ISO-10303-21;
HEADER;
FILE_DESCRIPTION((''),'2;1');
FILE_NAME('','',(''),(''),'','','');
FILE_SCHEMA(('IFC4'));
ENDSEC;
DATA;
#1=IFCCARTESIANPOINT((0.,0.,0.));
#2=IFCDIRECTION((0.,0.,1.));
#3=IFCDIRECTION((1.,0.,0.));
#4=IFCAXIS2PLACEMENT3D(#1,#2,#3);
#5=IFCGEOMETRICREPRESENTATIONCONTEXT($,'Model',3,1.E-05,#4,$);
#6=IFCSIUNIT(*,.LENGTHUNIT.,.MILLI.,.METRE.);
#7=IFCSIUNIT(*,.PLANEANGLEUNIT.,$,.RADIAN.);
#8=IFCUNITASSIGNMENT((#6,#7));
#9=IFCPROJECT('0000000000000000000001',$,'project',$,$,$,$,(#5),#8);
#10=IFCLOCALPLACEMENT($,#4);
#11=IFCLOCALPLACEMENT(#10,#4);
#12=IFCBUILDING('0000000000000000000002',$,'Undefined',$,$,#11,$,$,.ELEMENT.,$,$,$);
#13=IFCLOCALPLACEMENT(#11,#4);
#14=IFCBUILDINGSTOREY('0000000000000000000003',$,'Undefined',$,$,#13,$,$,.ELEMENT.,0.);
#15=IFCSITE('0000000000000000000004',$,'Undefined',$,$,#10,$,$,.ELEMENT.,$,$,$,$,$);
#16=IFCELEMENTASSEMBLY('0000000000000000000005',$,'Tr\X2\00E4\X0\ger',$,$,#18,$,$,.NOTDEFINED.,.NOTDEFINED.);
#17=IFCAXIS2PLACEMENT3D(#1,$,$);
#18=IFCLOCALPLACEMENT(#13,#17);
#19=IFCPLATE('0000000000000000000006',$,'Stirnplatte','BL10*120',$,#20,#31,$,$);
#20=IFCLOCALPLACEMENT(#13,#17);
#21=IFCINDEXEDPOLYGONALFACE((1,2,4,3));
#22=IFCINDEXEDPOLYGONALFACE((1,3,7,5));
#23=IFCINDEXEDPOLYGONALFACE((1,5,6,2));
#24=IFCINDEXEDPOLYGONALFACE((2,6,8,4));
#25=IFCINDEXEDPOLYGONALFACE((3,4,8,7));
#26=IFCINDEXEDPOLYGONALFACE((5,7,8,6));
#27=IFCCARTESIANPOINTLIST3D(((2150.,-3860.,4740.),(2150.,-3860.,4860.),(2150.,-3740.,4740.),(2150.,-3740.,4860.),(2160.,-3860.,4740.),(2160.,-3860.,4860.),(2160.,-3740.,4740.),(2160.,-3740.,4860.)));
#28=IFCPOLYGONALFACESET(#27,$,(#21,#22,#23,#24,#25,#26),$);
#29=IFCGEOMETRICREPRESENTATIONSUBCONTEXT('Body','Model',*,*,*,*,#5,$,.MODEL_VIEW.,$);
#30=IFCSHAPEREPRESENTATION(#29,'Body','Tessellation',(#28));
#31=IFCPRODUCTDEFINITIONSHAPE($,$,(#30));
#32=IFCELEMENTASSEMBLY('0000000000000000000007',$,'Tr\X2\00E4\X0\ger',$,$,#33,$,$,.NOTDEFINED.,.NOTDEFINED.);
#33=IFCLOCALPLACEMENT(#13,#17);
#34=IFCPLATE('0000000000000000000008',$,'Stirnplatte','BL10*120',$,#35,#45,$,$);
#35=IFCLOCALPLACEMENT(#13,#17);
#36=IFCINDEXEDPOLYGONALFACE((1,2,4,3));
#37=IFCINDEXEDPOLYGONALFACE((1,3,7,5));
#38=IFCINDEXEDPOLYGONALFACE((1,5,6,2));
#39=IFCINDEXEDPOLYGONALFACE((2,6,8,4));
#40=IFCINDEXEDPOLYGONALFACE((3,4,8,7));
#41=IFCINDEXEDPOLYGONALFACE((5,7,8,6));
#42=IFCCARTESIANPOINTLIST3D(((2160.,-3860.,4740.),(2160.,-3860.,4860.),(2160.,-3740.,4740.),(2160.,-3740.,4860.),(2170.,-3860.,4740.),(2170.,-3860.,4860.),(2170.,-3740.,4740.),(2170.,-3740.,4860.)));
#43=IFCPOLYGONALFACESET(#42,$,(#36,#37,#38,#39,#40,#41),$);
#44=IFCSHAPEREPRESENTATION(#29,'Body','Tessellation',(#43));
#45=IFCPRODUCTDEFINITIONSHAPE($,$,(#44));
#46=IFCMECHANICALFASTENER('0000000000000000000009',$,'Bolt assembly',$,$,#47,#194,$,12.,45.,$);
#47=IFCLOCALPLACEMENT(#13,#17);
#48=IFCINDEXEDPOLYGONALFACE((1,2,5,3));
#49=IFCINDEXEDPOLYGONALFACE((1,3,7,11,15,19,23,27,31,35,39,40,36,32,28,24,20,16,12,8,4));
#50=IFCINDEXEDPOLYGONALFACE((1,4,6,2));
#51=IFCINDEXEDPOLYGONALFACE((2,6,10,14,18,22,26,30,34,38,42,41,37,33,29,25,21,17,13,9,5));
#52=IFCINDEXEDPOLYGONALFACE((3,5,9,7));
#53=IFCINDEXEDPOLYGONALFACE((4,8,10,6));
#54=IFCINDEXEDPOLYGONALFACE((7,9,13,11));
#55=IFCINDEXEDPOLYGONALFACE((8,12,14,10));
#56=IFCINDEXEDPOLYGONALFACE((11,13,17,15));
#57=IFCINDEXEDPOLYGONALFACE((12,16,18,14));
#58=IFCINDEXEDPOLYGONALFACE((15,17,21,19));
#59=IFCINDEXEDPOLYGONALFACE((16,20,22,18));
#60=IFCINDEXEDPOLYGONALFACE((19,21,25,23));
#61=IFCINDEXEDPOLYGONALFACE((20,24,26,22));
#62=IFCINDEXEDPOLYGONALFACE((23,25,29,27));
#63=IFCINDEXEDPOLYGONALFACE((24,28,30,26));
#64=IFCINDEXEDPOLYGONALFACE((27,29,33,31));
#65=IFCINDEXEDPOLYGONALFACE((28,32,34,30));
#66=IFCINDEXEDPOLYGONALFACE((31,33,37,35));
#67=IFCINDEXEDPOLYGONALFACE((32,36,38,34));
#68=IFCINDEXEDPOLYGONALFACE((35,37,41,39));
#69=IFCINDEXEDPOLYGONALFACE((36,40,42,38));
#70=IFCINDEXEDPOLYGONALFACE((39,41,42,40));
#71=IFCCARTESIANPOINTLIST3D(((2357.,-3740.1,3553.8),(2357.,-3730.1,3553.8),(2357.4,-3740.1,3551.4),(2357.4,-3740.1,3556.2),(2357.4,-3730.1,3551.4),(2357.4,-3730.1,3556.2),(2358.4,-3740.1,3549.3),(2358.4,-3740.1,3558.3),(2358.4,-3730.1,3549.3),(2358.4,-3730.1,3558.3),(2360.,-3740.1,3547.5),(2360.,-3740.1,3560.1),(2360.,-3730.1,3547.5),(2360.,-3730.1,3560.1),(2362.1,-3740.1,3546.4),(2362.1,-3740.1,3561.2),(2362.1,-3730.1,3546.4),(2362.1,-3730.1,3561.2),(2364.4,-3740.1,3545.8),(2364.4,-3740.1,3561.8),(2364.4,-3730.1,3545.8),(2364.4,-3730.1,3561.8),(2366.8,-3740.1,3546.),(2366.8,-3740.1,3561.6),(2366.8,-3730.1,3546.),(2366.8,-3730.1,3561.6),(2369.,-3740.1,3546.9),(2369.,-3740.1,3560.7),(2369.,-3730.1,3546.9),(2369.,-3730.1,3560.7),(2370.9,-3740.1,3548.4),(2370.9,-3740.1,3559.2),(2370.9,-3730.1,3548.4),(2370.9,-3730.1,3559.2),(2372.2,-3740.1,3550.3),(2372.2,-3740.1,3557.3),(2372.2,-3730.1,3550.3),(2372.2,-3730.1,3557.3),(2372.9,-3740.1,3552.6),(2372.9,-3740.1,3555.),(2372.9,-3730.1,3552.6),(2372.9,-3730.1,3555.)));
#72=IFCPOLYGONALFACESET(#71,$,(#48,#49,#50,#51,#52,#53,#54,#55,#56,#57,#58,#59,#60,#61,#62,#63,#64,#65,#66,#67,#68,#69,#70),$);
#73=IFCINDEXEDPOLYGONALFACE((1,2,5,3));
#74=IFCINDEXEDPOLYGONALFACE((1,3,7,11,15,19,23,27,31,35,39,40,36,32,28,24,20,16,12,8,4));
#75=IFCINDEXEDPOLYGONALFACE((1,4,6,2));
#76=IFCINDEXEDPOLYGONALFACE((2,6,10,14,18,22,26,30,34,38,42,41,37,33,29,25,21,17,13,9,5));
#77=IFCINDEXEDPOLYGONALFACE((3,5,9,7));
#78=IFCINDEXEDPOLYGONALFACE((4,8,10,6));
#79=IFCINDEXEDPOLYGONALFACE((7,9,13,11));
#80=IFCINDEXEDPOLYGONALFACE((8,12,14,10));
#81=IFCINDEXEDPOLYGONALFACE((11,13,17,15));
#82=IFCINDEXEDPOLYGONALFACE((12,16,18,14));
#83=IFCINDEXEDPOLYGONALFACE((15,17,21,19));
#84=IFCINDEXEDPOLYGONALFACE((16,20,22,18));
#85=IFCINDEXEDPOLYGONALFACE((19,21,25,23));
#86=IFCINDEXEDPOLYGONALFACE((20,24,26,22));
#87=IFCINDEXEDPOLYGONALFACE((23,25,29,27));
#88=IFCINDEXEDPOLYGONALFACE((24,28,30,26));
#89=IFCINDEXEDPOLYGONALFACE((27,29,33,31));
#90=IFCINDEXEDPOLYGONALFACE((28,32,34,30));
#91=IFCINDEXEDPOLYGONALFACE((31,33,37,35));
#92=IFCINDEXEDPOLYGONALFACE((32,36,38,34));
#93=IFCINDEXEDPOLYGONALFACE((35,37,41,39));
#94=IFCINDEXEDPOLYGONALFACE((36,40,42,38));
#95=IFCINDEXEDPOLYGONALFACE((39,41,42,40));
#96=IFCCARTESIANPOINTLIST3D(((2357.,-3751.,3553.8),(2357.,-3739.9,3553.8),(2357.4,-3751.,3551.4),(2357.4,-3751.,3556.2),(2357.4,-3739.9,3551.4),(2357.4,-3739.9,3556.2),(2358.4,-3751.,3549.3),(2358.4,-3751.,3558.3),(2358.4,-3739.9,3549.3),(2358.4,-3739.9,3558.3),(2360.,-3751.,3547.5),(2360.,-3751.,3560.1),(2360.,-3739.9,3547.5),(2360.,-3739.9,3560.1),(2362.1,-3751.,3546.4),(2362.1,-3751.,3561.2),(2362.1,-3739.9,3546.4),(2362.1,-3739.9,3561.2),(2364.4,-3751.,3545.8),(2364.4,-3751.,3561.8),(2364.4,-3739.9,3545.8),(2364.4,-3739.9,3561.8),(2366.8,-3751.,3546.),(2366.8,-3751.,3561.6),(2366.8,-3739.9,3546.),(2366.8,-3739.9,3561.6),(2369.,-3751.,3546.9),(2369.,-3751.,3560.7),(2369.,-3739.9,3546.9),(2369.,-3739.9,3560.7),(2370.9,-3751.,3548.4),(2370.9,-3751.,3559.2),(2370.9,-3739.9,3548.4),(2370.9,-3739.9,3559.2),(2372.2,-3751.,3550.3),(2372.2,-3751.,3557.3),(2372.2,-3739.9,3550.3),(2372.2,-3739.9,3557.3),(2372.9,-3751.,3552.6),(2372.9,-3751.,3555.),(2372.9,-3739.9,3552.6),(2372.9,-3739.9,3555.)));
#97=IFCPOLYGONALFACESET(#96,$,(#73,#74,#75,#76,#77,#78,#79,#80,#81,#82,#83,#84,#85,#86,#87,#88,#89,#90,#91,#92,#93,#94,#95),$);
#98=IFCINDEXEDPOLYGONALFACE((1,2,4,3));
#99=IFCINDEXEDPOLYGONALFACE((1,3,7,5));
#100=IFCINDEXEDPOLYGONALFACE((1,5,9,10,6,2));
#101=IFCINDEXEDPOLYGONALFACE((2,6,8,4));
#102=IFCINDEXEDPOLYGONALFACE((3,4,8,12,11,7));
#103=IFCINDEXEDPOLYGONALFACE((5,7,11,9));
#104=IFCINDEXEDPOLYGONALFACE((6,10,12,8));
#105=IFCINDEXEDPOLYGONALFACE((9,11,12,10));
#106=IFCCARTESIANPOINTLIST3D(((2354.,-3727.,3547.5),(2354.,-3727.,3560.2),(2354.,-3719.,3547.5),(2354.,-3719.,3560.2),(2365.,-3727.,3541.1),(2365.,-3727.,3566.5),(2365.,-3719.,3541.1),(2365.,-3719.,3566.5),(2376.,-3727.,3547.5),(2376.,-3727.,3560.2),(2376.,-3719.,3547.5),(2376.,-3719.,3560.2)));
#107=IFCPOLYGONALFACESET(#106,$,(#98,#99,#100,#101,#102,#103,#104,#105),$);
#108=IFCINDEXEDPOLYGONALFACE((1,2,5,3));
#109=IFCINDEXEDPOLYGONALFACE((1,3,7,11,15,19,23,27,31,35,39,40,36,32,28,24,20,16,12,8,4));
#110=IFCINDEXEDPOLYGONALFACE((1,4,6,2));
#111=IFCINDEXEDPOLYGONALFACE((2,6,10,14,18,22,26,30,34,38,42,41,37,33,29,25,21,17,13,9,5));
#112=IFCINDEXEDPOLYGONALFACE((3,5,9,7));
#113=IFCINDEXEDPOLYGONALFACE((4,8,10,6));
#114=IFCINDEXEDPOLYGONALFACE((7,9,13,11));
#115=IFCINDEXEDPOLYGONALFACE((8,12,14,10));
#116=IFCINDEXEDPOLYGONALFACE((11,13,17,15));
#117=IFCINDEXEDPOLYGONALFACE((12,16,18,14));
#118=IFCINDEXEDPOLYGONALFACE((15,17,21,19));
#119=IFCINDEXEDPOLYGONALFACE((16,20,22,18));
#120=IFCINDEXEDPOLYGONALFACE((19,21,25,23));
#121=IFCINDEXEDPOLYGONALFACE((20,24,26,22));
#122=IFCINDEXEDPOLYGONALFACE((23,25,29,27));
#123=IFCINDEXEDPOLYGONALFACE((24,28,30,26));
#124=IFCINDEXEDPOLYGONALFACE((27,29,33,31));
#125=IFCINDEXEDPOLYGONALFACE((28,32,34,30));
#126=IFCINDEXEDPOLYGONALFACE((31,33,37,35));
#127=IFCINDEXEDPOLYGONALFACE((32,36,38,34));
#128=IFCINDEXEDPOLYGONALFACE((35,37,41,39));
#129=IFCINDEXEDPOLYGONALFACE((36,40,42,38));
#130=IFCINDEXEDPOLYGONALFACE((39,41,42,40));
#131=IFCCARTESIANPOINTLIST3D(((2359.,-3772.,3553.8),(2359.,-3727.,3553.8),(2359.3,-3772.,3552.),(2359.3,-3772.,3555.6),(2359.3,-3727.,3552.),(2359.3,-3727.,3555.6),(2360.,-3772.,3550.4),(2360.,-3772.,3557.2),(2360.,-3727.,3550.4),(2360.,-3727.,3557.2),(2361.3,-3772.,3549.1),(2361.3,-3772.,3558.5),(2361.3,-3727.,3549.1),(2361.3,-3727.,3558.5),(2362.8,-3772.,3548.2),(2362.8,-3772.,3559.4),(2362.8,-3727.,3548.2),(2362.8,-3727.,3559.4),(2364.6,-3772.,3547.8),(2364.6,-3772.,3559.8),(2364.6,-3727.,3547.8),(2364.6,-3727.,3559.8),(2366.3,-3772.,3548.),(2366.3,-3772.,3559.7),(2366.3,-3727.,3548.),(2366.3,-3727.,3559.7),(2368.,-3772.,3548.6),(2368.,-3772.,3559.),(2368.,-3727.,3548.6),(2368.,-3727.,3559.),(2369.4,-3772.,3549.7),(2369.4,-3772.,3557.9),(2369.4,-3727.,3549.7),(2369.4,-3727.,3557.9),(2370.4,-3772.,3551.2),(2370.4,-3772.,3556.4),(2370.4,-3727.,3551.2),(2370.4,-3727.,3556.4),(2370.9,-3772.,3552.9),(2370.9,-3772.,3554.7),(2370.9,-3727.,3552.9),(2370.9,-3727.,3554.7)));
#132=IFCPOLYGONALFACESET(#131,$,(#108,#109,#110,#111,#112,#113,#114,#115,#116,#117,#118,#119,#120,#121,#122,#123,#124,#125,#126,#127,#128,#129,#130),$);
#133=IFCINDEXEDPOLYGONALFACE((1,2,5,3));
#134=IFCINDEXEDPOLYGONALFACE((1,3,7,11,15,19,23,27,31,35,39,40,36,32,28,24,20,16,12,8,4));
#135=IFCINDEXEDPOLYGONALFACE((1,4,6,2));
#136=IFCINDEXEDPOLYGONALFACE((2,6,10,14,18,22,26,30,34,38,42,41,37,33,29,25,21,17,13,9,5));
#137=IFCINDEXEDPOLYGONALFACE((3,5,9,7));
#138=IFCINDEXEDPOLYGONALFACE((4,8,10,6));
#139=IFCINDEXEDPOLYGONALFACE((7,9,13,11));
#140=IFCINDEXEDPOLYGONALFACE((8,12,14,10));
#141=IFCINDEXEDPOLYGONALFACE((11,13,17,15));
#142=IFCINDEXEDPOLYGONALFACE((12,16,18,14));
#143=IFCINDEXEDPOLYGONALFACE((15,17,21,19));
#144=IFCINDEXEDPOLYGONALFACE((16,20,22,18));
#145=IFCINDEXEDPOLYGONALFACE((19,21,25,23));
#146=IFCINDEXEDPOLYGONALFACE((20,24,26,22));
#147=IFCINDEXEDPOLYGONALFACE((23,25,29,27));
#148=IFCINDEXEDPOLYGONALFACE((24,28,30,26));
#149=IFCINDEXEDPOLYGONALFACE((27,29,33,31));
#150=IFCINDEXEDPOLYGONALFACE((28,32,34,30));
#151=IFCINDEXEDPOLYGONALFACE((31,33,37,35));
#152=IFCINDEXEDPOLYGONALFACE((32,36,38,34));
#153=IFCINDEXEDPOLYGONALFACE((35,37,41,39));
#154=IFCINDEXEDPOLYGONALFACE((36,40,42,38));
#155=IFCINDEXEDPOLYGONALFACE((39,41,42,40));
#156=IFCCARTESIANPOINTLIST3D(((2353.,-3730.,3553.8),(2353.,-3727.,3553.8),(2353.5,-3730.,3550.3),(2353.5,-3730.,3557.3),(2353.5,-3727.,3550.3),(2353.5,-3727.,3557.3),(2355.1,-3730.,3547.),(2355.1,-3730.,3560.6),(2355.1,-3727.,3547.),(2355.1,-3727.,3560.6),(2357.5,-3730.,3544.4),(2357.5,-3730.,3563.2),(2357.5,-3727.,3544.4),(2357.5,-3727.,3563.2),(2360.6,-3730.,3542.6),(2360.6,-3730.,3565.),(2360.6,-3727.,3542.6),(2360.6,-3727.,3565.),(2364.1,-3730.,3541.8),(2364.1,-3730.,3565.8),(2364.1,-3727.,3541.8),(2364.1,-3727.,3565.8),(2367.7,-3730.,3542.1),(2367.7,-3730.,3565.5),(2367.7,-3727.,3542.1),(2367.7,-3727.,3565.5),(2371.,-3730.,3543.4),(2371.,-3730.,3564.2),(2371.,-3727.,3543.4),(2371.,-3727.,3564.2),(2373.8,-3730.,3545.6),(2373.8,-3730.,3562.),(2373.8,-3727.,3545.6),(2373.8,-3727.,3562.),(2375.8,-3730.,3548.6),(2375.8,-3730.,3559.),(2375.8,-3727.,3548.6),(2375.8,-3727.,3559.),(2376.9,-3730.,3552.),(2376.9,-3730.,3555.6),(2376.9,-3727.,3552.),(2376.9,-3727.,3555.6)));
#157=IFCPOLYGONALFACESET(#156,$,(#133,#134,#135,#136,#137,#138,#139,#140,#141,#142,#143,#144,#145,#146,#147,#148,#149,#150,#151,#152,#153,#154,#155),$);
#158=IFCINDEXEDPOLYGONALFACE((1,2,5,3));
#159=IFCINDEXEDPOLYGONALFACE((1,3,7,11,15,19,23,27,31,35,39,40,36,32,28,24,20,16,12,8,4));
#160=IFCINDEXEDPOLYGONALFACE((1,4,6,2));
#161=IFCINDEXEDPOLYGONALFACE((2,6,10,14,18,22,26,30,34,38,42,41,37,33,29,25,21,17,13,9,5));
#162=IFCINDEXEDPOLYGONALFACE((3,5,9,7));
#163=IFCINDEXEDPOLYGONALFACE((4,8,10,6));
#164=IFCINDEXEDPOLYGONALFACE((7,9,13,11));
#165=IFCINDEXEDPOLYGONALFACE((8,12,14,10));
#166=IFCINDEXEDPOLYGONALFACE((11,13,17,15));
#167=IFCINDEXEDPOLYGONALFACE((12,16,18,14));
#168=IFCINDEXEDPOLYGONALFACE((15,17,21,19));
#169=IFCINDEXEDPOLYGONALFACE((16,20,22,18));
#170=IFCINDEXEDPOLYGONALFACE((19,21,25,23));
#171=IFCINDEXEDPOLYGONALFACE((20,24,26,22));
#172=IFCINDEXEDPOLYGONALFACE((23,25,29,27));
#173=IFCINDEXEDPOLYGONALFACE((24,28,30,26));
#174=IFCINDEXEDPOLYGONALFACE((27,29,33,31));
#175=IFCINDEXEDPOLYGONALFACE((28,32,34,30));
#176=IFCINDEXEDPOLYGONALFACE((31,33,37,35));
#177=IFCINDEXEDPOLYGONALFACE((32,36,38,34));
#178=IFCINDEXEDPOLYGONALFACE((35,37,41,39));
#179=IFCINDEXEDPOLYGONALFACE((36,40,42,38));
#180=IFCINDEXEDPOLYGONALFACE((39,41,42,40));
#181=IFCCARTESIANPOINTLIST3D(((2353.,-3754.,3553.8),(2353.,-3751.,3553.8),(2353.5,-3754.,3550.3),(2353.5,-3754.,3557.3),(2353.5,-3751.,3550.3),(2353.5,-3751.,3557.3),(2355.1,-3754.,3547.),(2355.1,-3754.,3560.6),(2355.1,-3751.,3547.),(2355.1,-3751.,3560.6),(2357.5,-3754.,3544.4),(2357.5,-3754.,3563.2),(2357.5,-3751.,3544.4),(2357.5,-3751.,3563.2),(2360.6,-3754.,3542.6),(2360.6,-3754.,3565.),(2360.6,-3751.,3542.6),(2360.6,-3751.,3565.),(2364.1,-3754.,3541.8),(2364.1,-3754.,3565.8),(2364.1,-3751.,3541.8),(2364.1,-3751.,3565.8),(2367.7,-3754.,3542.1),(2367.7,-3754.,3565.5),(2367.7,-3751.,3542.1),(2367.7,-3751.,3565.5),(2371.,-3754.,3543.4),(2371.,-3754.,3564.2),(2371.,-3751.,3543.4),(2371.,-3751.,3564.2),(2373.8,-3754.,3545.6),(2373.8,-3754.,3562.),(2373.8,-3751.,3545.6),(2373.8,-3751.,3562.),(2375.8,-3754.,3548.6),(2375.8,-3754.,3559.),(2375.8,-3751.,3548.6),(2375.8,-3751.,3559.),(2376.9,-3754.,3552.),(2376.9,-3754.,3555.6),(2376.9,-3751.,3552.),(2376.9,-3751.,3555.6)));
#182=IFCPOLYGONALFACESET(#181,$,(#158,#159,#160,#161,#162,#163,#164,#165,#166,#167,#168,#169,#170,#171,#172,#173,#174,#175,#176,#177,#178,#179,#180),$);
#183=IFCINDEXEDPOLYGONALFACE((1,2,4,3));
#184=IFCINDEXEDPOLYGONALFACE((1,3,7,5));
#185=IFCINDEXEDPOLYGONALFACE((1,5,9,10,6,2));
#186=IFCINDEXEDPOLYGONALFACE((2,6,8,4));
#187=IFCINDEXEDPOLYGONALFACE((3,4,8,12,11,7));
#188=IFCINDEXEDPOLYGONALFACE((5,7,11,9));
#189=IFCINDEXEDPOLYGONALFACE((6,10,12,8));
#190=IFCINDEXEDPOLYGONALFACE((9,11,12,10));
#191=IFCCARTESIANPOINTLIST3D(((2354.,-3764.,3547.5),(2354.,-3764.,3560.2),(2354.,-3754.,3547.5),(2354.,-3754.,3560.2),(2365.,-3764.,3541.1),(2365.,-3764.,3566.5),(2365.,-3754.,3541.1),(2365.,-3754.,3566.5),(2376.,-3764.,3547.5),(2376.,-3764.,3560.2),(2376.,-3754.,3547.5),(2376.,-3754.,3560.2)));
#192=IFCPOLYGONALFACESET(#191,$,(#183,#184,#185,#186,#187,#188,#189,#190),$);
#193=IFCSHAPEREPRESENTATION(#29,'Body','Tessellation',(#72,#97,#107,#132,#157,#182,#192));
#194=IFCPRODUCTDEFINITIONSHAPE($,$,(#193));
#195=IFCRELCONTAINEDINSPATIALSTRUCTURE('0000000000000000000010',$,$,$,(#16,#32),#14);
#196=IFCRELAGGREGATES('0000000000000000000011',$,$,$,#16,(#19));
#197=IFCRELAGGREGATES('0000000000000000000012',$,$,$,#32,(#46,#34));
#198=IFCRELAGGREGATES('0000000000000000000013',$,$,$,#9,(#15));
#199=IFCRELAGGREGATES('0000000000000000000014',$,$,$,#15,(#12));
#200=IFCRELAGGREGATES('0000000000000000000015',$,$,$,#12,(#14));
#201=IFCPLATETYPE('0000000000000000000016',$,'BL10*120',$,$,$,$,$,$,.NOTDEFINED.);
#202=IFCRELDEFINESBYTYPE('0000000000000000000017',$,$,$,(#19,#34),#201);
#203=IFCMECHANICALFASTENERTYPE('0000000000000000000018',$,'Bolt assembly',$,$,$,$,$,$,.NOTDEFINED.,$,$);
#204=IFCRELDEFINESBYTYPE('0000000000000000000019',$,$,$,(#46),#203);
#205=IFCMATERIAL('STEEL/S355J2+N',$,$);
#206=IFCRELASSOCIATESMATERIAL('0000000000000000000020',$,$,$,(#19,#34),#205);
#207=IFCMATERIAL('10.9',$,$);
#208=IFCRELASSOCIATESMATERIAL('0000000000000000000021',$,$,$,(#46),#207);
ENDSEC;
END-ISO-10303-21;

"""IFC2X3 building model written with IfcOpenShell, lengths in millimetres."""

from ifc_helpers import new_model, si_unit, frame, origin_with_axes, origin_2d_with_axis, place, context, subcontext, project, spatial, polyline, circle, outline, extrude, source, transform, mapped, material, type_object, element, aggregate, save


model = new_model("IFC2X3")

# Units and contexts
model_context = context("Model", 3, precision=1e-05, world=origin_with_axes())
body_context = subcontext(model_context, "Body", "Model", "MODEL_VIEW")
ifc_project = project(units=[si_unit("LENGTHUNIT", "METRE", prefix="MILLI"), si_unit("PLANEANGLEUNIT", "RADIAN")], contexts=[model_context])

# Site, building, storey
site_placement = place(None, origin_with_axes())
site = spatial("IfcSite", under=ifc_project, at=site_placement, Name="Undefined", CompositionType="ELEMENT")
building_placement = place(site_placement, origin_with_axes())
building = spatial("IfcBuilding", under=site, at=building_placement, Name="Undefined", CompositionType="ELEMENT")
storey_placement = place(building_placement, origin_with_axes())
storey = spatial("IfcBuildingStorey", under=building, at=storey_placement, Name="Undefined", CompositionType="ELEMENT", Elevation=0.0)

# Element assembly
ifc_material_1 = material(Name="STEEL/S355J2+N")
plate_type_1 = type_object("IfcPlateType", Name="BL10*120", PredefinedType="NOTDEFINED")
assembly_1_placement = place(storey_placement, origin_with_axes())
assembly_1 = element("IfcElementAssembly", 1, at=assembly_1_placement, inside=storey, Name="Träger", AssemblyPlace="NOTDEFINED", PredefinedType="NOTDEFINED")

# Plate
plate_1_placement = place(assembly_1_placement, frame((2155.0, -3800.0, 4740.0), z_axis=(-1.0, 0.0, 0.0), x_axis=(0.0, 0.0, 1.0)))
plate_1 = element("IfcPlate", 2, at=plate_1_placement, type_object=plate_type_1, material=ifc_material_1, Name="Stirnplatte", Description="BL10*120", context=body_context, shape_type="SweptSolid", body=[
    extrude(outline(polyline([(0.0, -60.0), (0.0, 60.0), (120.0, 60.0), (120.0, -60.0), (0.0, -60.0)])), frame((0.0, 0.0, -5.0), z_axis=(0.0, 0.0, 1.0), x_axis=(1.0, 0.0, 0.0)), (0.0, 0.0, 1.0), 10.0),
])
aggregate(assembly_1, [plate_1])

# Element assembly, plate, mechanical fastener
assembly_2_placement = place(storey_placement, origin_with_axes())
assembly_2 = element("IfcElementAssembly", 3, at=assembly_2_placement, inside=storey, Name="Träger", AssemblyPlace="NOTDEFINED", PredefinedType="NOTDEFINED")
plate_2_placement = place(assembly_2_placement, frame((2165.0, -3800.0, 4740.0), z_axis=(-1.0, 0.0, 0.0), x_axis=(0.0, 0.0, 1.0)))
plate_2 = element("IfcPlate", 4, at=plate_2_placement, type_object=plate_type_1, material=ifc_material_1, Name="Stirnplatte", Description="BL10*120", context=body_context, shape_type="SweptSolid", body=[
    extrude(outline(polyline([(0.0, -60.0), (0.0, 60.0), (120.0, 60.0), (120.0, -60.0), (0.0, -60.0)])), frame((0.0, 0.0, -5.0), z_axis=(0.0, 0.0, 1.0), x_axis=(1.0, 0.0, 0.0)), (0.0, 0.0, 1.0), 10.0),
])
ifc_material_2 = material(Name="10.9")
mechanical_fastener_type = type_object("IfcMechanicalFastenerType", Name="Bolt assembly")
shared_shape = source(origin_with_axes(), body_context, "Body", "SweptSolid", [
    extrude(circle(Radius=8.0, at=origin_2d_with_axis()), frame((0.0, 0.1, 0.0), z_axis=(0.0, 1.0, 0.0), x_axis=(1.0, 0.0, 0.0)), (0.0, 0.0, 1.0), 10.0),
    extrude(circle(Radius=8.0, at=origin_2d_with_axis()), frame((0.0, 9.9, 0.0), z_axis=(0.0, 1.0, 0.0), x_axis=(1.0, 0.0, 0.0)), (0.0, 0.0, 1.0), 11.1),
    extrude(outline(polyline([(11.0, -6.4), (11.0, 6.4), (0.0, 12.7), (-11.0, 6.4), (-11.0, -6.4), (0.0, -12.7), (11.0, -6.4)])), frame((0.0, -11.0, 0.0), z_axis=(0.0, 1.0, 0.0), x_axis=(1.0, 0.0, 0.0)), (0.0, 0.0, 1.0), 8.0),
    extrude(circle(Radius=6.0, at=origin_2d_with_axis()), frame((0.0, -3.0, 0.0), z_axis=(0.0, 1.0, 0.0), x_axis=(1.0, 0.0, 0.0)), (0.0, 0.0, 1.0), 45.0),
    extrude(circle(Radius=12.0, at=origin_2d_with_axis()), frame((0.0, -3.0, 0.0), z_axis=(0.0, 1.0, 0.0), x_axis=(1.0, 0.0, 0.0)), (0.0, 0.0, 1.0), 3.0),
    extrude(circle(Radius=12.0, at=origin_2d_with_axis()), frame((0.0, 21.0, 0.0), z_axis=(0.0, 1.0, 0.0), x_axis=(1.0, 0.0, 0.0)), (0.0, 0.0, 1.0), 3.0),
    extrude(outline(polyline([(11.0, -6.4), (11.0, 6.4), (0.0, 12.7), (-11.0, 6.4), (-11.0, -6.4), (0.0, -12.7), (11.0, -6.4)])), frame((0.0, 24.0, 0.0), z_axis=(0.0, 1.0, 0.0), x_axis=(1.0, 0.0, 0.0)), (0.0, 0.0, 1.0), 10.0),
])
mechanical_fastener_1_placement = place(assembly_2_placement, frame((2365.0, -3730.0, 3553.8), z_axis=(0.0, 0.0, 1.0), x_axis=(-1.0, 0.0, 0.0)))
mechanical_fastener_1 = element("IfcMechanicalFastener", 5, at=mechanical_fastener_1_placement, type_object=mechanical_fastener_type, material=ifc_material_2, Name="Bolt assembly", NominalDiameter=12.0, NominalLength=45.0, context=body_context, shape_type="MappedRepresentation", body=[
    mapped(shared_shape, transform((0.0, 0.0, 0.0))),
])
aggregate(assembly_2, [mechanical_fastener_1, plate_2])

save(model, "model.ifc")
